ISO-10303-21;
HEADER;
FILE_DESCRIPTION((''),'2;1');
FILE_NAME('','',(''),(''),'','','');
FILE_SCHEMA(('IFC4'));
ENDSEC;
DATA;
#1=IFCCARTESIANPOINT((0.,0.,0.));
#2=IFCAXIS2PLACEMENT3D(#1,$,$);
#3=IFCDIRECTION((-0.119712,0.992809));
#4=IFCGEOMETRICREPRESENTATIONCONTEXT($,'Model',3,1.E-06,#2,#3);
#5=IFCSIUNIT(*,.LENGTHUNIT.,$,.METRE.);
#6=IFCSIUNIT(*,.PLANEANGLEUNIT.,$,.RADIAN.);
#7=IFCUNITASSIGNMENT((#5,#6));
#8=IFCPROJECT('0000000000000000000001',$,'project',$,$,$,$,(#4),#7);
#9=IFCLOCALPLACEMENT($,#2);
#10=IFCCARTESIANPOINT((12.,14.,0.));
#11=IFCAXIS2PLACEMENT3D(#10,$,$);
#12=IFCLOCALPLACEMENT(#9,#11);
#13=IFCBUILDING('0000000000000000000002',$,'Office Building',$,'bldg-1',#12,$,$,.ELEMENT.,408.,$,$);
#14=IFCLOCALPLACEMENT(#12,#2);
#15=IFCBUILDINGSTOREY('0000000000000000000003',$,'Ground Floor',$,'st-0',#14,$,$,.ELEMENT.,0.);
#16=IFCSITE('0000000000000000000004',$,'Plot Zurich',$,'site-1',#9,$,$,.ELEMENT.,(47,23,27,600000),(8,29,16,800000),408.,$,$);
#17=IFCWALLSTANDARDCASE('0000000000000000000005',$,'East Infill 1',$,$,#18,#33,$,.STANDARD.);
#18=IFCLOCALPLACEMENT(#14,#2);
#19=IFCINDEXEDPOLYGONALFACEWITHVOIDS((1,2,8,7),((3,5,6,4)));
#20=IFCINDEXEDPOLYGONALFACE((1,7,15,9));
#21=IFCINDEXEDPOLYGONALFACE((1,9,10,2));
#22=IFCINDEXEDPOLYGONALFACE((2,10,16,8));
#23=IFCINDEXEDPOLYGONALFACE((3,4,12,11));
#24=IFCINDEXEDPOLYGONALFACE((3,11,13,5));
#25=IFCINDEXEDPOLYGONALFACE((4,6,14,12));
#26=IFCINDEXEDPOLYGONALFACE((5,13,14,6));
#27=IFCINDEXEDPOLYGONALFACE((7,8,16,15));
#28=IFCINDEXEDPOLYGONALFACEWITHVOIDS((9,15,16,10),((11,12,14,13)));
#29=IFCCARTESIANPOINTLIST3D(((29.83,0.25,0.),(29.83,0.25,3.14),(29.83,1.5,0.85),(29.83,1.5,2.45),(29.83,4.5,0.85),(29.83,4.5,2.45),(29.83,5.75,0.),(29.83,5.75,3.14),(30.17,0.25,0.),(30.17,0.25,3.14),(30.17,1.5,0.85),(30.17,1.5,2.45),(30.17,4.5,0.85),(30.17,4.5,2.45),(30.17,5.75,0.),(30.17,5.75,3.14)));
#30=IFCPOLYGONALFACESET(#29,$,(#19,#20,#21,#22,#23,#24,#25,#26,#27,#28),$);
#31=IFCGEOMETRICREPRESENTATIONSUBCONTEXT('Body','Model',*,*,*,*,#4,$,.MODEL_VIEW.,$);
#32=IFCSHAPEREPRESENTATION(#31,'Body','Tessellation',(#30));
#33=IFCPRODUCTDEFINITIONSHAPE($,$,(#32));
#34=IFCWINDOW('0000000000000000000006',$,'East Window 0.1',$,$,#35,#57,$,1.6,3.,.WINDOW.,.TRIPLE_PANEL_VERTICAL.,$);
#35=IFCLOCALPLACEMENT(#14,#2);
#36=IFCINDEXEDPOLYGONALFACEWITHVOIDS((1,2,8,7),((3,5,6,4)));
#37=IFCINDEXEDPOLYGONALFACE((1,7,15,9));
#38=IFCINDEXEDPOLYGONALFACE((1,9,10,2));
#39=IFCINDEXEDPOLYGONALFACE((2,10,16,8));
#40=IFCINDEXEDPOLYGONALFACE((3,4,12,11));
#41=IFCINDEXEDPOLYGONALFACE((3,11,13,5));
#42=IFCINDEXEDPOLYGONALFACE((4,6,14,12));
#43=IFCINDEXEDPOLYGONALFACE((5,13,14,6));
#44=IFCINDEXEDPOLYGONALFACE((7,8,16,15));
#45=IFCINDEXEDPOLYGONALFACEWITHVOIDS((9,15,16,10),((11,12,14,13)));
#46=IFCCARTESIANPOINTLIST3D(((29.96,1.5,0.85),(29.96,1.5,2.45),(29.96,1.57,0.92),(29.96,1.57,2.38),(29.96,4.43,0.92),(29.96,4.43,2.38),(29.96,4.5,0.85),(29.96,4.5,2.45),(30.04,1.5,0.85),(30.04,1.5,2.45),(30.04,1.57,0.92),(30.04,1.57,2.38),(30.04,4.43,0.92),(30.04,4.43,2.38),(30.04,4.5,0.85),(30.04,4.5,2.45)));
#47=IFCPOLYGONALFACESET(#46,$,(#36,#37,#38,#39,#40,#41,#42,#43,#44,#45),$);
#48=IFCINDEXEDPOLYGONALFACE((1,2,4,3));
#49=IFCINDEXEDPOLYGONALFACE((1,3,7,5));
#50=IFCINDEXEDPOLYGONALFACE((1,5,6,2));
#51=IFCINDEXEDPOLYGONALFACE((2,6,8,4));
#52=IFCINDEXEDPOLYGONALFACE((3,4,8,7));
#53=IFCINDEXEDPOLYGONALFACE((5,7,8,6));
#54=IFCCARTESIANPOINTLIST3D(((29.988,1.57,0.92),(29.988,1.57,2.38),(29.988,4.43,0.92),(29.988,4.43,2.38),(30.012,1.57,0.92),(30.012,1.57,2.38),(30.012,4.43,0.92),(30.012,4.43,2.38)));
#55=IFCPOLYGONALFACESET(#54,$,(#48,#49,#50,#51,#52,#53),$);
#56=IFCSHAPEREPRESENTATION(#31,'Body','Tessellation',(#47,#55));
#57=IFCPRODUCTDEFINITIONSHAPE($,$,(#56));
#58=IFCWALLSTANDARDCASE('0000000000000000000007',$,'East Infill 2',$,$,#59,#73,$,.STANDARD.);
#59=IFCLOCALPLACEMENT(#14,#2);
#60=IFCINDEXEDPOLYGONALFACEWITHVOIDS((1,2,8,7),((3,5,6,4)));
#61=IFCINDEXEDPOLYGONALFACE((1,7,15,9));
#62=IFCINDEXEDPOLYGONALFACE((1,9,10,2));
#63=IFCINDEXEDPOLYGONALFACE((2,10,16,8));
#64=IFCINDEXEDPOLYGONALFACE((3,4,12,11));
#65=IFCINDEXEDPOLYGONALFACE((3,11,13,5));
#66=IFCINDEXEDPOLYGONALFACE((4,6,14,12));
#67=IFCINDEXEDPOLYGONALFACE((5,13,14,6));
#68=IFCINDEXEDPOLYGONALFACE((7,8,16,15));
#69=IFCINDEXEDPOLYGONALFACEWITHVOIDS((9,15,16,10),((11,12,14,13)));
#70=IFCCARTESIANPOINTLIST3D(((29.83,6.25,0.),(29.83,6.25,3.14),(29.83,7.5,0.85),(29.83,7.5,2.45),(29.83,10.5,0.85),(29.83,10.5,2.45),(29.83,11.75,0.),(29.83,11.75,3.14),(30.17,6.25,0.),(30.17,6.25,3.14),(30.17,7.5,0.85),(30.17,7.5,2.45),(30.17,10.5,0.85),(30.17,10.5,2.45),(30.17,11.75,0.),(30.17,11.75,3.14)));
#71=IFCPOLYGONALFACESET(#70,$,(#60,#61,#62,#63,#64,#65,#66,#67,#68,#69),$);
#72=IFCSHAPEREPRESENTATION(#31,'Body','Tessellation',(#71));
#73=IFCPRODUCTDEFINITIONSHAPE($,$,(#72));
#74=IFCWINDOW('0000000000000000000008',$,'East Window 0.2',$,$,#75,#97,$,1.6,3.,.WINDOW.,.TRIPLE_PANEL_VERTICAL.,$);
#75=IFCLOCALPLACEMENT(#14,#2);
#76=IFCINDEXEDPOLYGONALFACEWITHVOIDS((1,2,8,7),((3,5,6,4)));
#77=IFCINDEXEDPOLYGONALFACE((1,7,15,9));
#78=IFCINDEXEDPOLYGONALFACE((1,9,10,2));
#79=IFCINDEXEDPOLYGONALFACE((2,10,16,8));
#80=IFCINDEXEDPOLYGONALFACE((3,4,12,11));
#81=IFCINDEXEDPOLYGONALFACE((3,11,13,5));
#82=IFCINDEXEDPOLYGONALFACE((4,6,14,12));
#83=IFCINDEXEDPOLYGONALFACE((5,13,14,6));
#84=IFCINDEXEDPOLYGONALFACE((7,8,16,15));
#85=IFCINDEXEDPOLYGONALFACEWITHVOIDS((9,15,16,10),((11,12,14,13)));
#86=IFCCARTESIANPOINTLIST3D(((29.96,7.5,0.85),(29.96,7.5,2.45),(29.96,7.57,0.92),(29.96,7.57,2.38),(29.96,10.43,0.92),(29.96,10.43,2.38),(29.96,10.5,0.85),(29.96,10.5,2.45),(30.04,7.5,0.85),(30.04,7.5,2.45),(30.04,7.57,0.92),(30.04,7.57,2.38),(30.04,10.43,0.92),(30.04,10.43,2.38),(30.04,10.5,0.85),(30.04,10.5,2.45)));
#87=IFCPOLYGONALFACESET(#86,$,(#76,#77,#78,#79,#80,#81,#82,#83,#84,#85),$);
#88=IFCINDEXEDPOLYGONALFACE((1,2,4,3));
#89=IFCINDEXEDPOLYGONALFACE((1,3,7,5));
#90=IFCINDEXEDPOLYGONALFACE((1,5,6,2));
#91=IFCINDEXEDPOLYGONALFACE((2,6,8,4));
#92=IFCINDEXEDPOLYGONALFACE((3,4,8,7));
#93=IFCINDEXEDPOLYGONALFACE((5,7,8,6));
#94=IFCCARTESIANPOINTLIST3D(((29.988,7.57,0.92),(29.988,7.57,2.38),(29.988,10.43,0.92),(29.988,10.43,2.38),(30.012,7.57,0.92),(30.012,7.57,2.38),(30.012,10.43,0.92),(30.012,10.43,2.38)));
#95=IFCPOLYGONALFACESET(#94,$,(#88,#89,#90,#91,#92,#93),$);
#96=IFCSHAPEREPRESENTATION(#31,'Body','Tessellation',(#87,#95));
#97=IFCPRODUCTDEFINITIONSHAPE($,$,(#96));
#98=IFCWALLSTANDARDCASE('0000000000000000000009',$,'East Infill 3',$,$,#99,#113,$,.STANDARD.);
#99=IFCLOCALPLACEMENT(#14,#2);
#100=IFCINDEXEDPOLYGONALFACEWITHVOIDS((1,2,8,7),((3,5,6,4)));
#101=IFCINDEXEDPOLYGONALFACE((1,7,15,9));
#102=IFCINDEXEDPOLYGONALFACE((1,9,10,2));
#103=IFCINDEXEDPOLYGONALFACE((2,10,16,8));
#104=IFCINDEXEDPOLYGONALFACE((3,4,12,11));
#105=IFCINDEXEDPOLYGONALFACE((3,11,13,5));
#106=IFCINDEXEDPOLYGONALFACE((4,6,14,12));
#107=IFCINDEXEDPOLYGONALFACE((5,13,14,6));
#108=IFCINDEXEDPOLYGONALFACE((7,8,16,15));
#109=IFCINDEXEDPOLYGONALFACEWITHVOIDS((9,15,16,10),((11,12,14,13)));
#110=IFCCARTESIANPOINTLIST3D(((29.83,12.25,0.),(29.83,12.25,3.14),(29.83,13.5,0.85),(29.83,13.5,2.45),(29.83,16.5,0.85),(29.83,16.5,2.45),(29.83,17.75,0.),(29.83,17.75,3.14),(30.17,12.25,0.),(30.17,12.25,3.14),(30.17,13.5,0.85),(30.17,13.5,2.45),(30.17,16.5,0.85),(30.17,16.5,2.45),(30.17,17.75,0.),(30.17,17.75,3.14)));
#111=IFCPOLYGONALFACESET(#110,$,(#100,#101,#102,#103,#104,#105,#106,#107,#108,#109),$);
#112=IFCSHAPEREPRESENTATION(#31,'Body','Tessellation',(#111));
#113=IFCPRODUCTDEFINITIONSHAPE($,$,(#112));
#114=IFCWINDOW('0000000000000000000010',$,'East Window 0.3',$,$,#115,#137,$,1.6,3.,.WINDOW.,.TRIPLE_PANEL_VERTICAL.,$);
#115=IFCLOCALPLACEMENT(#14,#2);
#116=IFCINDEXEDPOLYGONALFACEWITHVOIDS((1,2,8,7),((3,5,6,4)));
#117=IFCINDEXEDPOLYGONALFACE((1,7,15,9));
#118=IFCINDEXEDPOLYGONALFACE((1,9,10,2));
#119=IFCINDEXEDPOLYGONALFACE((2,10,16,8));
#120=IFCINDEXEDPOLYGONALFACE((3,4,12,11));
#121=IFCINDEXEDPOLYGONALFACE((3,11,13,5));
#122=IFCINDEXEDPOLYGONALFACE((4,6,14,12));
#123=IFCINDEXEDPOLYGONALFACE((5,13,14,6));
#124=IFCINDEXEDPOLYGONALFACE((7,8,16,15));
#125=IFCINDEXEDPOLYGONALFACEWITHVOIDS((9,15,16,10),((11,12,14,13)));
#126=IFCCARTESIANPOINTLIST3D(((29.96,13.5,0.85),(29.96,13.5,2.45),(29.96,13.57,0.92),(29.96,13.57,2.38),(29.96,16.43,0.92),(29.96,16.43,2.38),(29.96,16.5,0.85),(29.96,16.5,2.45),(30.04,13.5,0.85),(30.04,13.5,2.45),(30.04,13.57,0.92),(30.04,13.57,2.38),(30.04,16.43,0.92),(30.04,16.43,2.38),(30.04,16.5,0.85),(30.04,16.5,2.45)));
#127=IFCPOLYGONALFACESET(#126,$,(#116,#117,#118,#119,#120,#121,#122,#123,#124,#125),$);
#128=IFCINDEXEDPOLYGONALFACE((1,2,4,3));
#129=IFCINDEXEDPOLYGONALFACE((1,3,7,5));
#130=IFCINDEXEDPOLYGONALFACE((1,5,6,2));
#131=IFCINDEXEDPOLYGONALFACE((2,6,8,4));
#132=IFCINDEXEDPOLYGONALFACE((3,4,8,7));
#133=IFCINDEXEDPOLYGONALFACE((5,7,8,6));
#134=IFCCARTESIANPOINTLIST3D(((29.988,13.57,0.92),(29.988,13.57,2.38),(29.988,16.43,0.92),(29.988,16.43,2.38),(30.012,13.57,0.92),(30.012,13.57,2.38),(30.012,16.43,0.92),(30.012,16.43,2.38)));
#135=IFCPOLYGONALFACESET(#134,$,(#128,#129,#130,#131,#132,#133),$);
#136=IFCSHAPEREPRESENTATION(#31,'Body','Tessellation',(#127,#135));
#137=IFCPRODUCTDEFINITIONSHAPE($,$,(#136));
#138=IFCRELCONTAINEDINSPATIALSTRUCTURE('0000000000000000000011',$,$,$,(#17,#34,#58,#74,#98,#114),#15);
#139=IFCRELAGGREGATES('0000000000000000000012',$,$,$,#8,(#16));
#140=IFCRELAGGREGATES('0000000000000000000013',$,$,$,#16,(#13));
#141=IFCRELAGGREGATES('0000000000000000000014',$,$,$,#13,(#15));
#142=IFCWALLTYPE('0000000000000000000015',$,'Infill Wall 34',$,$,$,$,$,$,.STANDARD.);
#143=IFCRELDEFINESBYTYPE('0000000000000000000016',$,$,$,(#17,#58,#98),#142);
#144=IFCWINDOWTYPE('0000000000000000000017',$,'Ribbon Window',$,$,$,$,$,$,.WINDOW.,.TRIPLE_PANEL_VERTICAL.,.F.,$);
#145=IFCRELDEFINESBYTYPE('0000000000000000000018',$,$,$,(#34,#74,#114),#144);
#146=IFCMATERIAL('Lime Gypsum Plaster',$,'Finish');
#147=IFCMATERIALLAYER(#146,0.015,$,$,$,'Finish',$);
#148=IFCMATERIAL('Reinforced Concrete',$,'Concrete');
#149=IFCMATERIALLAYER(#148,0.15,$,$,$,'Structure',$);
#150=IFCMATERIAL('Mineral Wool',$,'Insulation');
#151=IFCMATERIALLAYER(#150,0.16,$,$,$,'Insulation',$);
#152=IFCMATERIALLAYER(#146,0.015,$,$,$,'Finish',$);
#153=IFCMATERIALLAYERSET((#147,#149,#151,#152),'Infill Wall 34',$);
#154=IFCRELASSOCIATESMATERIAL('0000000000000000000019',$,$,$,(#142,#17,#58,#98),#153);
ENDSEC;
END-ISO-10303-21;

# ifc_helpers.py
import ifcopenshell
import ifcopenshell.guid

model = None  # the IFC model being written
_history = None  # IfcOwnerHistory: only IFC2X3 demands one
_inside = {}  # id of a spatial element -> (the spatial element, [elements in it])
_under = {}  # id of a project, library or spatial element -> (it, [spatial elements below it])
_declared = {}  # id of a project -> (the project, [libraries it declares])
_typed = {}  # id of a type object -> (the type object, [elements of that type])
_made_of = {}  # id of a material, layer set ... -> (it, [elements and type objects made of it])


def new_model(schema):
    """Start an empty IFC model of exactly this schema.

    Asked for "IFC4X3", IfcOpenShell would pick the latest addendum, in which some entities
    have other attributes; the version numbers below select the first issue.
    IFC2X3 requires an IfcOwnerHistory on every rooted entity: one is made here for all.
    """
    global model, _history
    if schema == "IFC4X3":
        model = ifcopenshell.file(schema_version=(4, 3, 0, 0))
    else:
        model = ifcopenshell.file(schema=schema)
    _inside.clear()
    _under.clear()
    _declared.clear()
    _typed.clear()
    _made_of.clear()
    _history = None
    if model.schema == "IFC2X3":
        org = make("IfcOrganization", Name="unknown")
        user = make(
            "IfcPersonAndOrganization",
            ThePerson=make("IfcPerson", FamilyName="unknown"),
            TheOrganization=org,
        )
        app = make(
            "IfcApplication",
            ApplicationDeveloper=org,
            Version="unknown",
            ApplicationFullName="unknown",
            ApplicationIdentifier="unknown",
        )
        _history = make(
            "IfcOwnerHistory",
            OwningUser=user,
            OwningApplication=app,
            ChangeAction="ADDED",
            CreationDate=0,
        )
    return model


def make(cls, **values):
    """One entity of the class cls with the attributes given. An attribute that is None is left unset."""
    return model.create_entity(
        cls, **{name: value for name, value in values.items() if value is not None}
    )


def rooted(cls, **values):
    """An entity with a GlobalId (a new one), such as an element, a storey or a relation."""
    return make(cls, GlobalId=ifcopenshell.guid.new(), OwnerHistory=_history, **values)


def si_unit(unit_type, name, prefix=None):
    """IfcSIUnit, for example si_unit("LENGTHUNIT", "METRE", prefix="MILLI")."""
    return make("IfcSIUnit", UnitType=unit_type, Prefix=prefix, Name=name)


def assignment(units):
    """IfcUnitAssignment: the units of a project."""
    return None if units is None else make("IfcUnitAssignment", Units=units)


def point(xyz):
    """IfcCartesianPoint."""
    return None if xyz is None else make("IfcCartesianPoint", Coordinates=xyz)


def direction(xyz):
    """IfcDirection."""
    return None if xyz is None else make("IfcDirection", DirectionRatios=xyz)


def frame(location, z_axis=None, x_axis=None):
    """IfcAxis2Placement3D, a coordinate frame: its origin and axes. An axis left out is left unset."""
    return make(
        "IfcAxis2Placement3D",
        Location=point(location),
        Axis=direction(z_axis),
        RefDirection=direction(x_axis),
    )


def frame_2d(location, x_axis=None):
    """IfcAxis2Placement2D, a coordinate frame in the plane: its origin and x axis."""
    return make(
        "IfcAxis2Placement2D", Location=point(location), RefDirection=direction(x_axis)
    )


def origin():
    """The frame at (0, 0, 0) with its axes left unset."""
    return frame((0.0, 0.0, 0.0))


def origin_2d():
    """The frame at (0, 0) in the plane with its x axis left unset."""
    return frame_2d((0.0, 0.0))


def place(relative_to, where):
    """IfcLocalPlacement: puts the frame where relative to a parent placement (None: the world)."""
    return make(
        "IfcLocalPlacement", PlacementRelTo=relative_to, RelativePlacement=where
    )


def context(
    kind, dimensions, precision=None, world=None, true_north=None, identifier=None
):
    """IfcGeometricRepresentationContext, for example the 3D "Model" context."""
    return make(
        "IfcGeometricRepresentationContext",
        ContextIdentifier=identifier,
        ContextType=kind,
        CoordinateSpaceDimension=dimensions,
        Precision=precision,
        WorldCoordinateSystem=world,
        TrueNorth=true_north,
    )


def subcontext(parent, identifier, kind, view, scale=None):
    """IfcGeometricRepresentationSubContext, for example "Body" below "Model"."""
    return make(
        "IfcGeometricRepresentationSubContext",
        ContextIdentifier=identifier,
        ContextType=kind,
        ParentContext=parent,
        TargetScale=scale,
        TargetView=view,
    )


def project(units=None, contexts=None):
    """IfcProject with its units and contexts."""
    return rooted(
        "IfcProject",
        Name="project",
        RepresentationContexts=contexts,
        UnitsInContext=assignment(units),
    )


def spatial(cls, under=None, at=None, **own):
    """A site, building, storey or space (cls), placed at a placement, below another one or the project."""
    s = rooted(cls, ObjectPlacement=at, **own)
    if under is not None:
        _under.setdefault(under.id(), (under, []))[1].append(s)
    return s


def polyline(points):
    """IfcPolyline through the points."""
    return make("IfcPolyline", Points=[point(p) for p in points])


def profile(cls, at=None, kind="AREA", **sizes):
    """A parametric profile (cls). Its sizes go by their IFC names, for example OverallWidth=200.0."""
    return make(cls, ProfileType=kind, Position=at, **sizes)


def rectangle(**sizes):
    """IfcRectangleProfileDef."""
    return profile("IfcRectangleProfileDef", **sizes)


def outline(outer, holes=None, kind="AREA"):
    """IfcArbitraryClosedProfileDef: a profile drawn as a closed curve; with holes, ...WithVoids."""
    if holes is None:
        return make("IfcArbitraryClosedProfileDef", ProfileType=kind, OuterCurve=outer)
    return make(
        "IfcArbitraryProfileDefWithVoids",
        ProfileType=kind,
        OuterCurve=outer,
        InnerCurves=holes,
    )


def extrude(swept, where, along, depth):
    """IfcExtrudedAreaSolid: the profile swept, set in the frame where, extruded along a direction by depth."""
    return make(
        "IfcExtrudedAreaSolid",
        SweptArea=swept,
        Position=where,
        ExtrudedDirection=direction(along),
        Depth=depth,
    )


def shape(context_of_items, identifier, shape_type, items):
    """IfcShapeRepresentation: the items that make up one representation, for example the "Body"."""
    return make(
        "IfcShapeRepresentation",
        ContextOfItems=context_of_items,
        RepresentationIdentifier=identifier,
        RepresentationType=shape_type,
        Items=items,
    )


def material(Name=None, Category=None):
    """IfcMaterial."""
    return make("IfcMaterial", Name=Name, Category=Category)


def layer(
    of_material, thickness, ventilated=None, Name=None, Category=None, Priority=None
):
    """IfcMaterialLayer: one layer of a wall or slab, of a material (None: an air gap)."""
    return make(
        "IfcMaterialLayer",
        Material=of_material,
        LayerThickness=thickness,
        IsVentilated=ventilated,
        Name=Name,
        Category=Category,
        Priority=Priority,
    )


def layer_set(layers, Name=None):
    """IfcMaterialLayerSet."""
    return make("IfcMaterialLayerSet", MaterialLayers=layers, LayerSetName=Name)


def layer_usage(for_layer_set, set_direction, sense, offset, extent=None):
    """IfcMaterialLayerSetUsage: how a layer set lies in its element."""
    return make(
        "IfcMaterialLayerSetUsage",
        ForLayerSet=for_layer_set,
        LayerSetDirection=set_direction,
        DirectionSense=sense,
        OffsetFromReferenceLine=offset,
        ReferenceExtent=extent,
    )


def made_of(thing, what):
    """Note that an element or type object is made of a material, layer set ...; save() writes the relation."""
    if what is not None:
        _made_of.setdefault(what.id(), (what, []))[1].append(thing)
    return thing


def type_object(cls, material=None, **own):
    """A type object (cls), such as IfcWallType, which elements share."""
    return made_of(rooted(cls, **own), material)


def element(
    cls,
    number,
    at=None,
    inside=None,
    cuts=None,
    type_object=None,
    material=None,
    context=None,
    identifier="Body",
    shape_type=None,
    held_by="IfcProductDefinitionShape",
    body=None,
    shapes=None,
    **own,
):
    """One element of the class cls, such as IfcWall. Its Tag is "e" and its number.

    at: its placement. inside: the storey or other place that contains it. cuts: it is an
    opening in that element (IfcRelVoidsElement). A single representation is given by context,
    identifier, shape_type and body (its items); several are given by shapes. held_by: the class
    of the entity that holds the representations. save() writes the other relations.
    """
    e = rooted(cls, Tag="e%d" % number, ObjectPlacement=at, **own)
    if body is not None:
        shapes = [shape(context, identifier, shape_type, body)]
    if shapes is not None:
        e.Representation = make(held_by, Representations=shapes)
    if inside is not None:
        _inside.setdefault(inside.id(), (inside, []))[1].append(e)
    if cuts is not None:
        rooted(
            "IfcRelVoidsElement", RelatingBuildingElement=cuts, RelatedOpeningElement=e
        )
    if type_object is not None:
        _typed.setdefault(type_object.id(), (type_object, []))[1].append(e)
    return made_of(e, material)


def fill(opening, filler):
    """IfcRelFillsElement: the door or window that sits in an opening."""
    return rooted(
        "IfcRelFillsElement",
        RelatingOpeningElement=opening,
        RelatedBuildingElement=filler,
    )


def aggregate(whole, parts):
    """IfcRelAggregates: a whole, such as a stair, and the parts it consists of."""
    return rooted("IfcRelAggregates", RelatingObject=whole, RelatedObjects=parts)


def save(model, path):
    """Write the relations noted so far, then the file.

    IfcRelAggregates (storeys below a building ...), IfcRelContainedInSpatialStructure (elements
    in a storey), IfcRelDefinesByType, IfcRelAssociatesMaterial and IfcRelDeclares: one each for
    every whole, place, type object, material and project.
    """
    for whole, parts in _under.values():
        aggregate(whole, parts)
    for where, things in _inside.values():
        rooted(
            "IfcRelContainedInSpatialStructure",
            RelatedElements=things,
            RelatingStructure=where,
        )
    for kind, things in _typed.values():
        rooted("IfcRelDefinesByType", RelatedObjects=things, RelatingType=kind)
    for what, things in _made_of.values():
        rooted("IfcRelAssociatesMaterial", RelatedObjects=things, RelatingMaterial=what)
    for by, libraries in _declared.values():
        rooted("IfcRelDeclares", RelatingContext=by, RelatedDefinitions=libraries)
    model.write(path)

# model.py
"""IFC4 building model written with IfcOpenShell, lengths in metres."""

from ifc_helpers import new_model, si_unit, direction, frame, frame_2d, origin, origin_2d, place, context, subcontext, project, spatial, polyline, rectangle, outline, extrude, material, layer, layer_set, layer_usage, type_object, element, fill, save


model = new_model("IFC4")

# Units and contexts
model_context = context("Model", 3, precision=1e-06, world=origin(), true_north=direction((-0.119712, 0.992809)))
body_context = subcontext(model_context, "Body", "Model", "MODEL_VIEW")
ifc_project = project(units=[si_unit("LENGTHUNIT", "METRE"), si_unit("PLANEANGLEUNIT", "RADIAN")], contexts=[model_context])

# Site, building, storey
site_placement = place(None, origin())
site = spatial("IfcSite", under=ifc_project, at=site_placement, Name="Plot Zurich", ObjectType="site-1", CompositionType="ELEMENT", RefLatitude=(47, 23, 27, 600000), RefLongitude=(8, 29, 16, 800000), RefElevation=408.0)
building_placement = place(site_placement, frame((12.0, 14.0, 0.0)))
building = spatial("IfcBuilding", under=site, at=building_placement, Name="Office Building", ObjectType="bldg-1", CompositionType="ELEMENT", ElevationOfRefHeight=408.0)
storey_placement = place(building_placement, origin())
storey = spatial("IfcBuildingStorey", under=building, at=storey_placement, Name="Ground Floor", ObjectType="st-0", CompositionType="ELEMENT", Elevation=0.0)

# Shared definitions
ifc_material_1 = material(Name="Reinforced Concrete", Category="Concrete")

# Walls, openings, windows
ifc_material_2 = material(Name="Lime Gypsum Plaster", Category="Finish")
ifc_layer_1 = layer(ifc_material_2, 0.015, Category="Finish")
ifc_layer_2 = layer(ifc_material_1, 0.15, Category="Structure")
ifc_material_3 = material(Name="Mineral Wool", Category="Insulation")
ifc_layer_3 = layer(ifc_material_3, 0.16, Category="Insulation")
ifc_layer_4 = layer(ifc_material_2, 0.015, Category="Finish")
ifc_layer_set = layer_set([ifc_layer_1, ifc_layer_2, ifc_layer_3, ifc_layer_4], Name="Infill Wall 34")
ifc_layer_usage_1 = layer_usage(ifc_layer_set, "AXIS2", "NEGATIVE", 0.17)
wall_type = type_object("IfcWallType", Name="Infill Wall 34", PredefinedType="STANDARD", material=ifc_layer_set)
wall_1_placement = place(storey_placement, frame((30.0, 0.25, 0.0), z_axis=(0.0, 0.0, 1.0), x_axis=(0.0, 1.0, 0.0)))
wall_1 = element("IfcWallStandardCase", 1, at=wall_1_placement, inside=storey, type_object=wall_type, material=ifc_layer_usage_1, Name="East Infill 1", PredefinedType="STANDARD", context=body_context, shape_type="SweptSolid", body=[
    extrude(rectangle(XDim=5.5, YDim=0.34, at=frame_2d((2.75, 0.0))), origin(), (0.0, 0.0, 1.0), 3.14),
])
opening_1_placement = place(wall_1_placement, frame((2.75, 0.0, 0.85)))
opening_1 = element("IfcOpeningElement", 2, at=opening_1_placement, cuts=wall_1, PredefinedType="OPENING", context=body_context, shape_type="SweptSolid", body=[
    extrude(rectangle(XDim=3.0, YDim=0.34, at=origin_2d()), origin(), (0.0, 0.0, 1.0), 1.6),
])
window_type = type_object("IfcWindowType", Name="Ribbon Window", ParameterTakesPrecedence=False, PartitioningType="TRIPLE_PANEL_VERTICAL", PredefinedType="WINDOW")
window_1_placement = place(opening_1_placement, frame((0.0, 0.0, 0.0), z_axis=(0.0, 1.0, 0.0), x_axis=(-1.0, 0.0, 0.0)))
window_1 = element("IfcWindow", 3, at=window_1_placement, inside=storey, type_object=window_type, Name="East Window 0.1", OverallHeight=1.6, OverallWidth=3.0, PartitioningType="TRIPLE_PANEL_VERTICAL", PredefinedType="WINDOW", context=body_context, shape_type="SweptSolid", body=[
    extrude(outline(polyline([(-1.5, 0.0), (1.5, 0.0), (1.5, 1.6), (-1.5, 1.6), (-1.5, 0.0)]), holes=[polyline([(-1.43, 0.07), (1.43, 0.07), (1.43, 1.53), (-1.43, 1.53), (-1.43, 0.07)])]), frame((0.0, 0.0, -0.04)), (0.0, 0.0, 1.0), 0.08),
    extrude(rectangle(XDim=2.86, YDim=1.46, at=frame_2d((0.0, 0.8))), frame((0.0, 0.0, -0.012)), (0.0, 0.0, 1.0), 0.024),
])
fill(opening_1, window_1)
ifc_layer_usage_2 = layer_usage(ifc_layer_set, "AXIS2", "NEGATIVE", 0.17)
wall_2_placement = place(storey_placement, frame((30.0, 6.25, 0.0), z_axis=(0.0, 0.0, 1.0), x_axis=(0.0, 1.0, 0.0)))
wall_2 = element("IfcWallStandardCase", 4, at=wall_2_placement, inside=storey, type_object=wall_type, material=ifc_layer_usage_2, Name="East Infill 2", PredefinedType="STANDARD", context=body_context, shape_type="SweptSolid", body=[
    extrude(rectangle(XDim=5.5, YDim=0.34, at=frame_2d((2.75, 0.0))), origin(), (0.0, 0.0, 1.0), 3.14),
])
opening_2_placement = place(wall_2_placement, frame((2.75, 0.0, 0.85)))
opening_2 = element("IfcOpeningElement", 5, at=opening_2_placement, cuts=wall_2, PredefinedType="OPENING", context=body_context, shape_type="SweptSolid", body=[
    extrude(rectangle(XDim=3.0, YDim=0.34, at=origin_2d()), origin(), (0.0, 0.0, 1.0), 1.6),
])
window_2_placement = place(opening_2_placement, frame((0.0, 0.0, 0.0), z_axis=(0.0, 1.0, 0.0), x_axis=(-1.0, 0.0, 0.0)))
window_2 = element("IfcWindow", 6, at=window_2_placement, inside=storey, type_object=window_type, Name="East Window 0.2", OverallHeight=1.6, OverallWidth=3.0, PartitioningType="TRIPLE_PANEL_VERTICAL", PredefinedType="WINDOW", context=body_context, shape_type="SweptSolid", body=[
    extrude(outline(polyline([(-1.5, 0.0), (1.5, 0.0), (1.5, 1.6), (-1.5, 1.6), (-1.5, 0.0)]), holes=[polyline([(-1.43, 0.07), (1.43, 0.07), (1.43, 1.53), (-1.43, 1.53), (-1.43, 0.07)])]), frame((0.0, 0.0, -0.04)), (0.0, 0.0, 1.0), 0.08),
    extrude(rectangle(XDim=2.86, YDim=1.46, at=frame_2d((0.0, 0.8))), frame((0.0, 0.0, -0.012)), (0.0, 0.0, 1.0), 0.024),
])
fill(opening_2, window_2)
ifc_layer_usage_3 = layer_usage(ifc_layer_set, "AXIS2", "NEGATIVE", 0.17)
wall_3_placement = place(storey_placement, frame((30.0, 12.25, 0.0), z_axis=(0.0, 0.0, 1.0), x_axis=(0.0, 1.0, 0.0)))
wall_3 = element("IfcWallStandardCase", 7, at=wall_3_placement, inside=storey, type_object=wall_type, material=ifc_layer_usage_3, Name="East Infill 3", PredefinedType="STANDARD", context=body_context, shape_type="SweptSolid", body=[
    extrude(rectangle(XDim=5.5, YDim=0.34, at=frame_2d((2.75, 0.0))), origin(), (0.0, 0.0, 1.0), 3.14),
])
opening_3_placement = place(wall_3_placement, frame((2.75, 0.0, 0.85)))
opening_3 = element("IfcOpeningElement", 8, at=opening_3_placement, cuts=wall_3, PredefinedType="OPENING", context=body_context, shape_type="SweptSolid", body=[
    extrude(rectangle(XDim=3.0, YDim=0.34, at=origin_2d()), origin(), (0.0, 0.0, 1.0), 1.6),
])
window_3_placement = place(opening_3_placement, frame((0.0, 0.0, 0.0), z_axis=(0.0, 1.0, 0.0), x_axis=(-1.0, 0.0, 0.0)))
window_3 = element("IfcWindow", 9, at=window_3_placement, inside=storey, type_object=window_type, Name="East Window 0.3", OverallHeight=1.6, OverallWidth=3.0, PartitioningType="TRIPLE_PANEL_VERTICAL", PredefinedType="WINDOW", context=body_context, shape_type="SweptSolid", body=[
    extrude(outline(polyline([(-1.5, 0.0), (1.5, 0.0), (1.5, 1.6), (-1.5, 1.6), (-1.5, 0.0)]), holes=[polyline([(-1.43, 0.07), (1.43, 0.07), (1.43, 1.53), (-1.43, 1.53), (-1.43, 0.07)])]), frame((0.0, 0.0, -0.04)), (0.0, 0.0, 1.0), 0.08),
    extrude(rectangle(XDim=2.86, YDim=1.46, at=frame_2d((0.0, 0.8))), frame((0.0, 0.0, -0.012)), (0.0, 0.0, 1.0), 0.024),
])
fill(opening_3, window_3)

save(model, "model.ifc")
